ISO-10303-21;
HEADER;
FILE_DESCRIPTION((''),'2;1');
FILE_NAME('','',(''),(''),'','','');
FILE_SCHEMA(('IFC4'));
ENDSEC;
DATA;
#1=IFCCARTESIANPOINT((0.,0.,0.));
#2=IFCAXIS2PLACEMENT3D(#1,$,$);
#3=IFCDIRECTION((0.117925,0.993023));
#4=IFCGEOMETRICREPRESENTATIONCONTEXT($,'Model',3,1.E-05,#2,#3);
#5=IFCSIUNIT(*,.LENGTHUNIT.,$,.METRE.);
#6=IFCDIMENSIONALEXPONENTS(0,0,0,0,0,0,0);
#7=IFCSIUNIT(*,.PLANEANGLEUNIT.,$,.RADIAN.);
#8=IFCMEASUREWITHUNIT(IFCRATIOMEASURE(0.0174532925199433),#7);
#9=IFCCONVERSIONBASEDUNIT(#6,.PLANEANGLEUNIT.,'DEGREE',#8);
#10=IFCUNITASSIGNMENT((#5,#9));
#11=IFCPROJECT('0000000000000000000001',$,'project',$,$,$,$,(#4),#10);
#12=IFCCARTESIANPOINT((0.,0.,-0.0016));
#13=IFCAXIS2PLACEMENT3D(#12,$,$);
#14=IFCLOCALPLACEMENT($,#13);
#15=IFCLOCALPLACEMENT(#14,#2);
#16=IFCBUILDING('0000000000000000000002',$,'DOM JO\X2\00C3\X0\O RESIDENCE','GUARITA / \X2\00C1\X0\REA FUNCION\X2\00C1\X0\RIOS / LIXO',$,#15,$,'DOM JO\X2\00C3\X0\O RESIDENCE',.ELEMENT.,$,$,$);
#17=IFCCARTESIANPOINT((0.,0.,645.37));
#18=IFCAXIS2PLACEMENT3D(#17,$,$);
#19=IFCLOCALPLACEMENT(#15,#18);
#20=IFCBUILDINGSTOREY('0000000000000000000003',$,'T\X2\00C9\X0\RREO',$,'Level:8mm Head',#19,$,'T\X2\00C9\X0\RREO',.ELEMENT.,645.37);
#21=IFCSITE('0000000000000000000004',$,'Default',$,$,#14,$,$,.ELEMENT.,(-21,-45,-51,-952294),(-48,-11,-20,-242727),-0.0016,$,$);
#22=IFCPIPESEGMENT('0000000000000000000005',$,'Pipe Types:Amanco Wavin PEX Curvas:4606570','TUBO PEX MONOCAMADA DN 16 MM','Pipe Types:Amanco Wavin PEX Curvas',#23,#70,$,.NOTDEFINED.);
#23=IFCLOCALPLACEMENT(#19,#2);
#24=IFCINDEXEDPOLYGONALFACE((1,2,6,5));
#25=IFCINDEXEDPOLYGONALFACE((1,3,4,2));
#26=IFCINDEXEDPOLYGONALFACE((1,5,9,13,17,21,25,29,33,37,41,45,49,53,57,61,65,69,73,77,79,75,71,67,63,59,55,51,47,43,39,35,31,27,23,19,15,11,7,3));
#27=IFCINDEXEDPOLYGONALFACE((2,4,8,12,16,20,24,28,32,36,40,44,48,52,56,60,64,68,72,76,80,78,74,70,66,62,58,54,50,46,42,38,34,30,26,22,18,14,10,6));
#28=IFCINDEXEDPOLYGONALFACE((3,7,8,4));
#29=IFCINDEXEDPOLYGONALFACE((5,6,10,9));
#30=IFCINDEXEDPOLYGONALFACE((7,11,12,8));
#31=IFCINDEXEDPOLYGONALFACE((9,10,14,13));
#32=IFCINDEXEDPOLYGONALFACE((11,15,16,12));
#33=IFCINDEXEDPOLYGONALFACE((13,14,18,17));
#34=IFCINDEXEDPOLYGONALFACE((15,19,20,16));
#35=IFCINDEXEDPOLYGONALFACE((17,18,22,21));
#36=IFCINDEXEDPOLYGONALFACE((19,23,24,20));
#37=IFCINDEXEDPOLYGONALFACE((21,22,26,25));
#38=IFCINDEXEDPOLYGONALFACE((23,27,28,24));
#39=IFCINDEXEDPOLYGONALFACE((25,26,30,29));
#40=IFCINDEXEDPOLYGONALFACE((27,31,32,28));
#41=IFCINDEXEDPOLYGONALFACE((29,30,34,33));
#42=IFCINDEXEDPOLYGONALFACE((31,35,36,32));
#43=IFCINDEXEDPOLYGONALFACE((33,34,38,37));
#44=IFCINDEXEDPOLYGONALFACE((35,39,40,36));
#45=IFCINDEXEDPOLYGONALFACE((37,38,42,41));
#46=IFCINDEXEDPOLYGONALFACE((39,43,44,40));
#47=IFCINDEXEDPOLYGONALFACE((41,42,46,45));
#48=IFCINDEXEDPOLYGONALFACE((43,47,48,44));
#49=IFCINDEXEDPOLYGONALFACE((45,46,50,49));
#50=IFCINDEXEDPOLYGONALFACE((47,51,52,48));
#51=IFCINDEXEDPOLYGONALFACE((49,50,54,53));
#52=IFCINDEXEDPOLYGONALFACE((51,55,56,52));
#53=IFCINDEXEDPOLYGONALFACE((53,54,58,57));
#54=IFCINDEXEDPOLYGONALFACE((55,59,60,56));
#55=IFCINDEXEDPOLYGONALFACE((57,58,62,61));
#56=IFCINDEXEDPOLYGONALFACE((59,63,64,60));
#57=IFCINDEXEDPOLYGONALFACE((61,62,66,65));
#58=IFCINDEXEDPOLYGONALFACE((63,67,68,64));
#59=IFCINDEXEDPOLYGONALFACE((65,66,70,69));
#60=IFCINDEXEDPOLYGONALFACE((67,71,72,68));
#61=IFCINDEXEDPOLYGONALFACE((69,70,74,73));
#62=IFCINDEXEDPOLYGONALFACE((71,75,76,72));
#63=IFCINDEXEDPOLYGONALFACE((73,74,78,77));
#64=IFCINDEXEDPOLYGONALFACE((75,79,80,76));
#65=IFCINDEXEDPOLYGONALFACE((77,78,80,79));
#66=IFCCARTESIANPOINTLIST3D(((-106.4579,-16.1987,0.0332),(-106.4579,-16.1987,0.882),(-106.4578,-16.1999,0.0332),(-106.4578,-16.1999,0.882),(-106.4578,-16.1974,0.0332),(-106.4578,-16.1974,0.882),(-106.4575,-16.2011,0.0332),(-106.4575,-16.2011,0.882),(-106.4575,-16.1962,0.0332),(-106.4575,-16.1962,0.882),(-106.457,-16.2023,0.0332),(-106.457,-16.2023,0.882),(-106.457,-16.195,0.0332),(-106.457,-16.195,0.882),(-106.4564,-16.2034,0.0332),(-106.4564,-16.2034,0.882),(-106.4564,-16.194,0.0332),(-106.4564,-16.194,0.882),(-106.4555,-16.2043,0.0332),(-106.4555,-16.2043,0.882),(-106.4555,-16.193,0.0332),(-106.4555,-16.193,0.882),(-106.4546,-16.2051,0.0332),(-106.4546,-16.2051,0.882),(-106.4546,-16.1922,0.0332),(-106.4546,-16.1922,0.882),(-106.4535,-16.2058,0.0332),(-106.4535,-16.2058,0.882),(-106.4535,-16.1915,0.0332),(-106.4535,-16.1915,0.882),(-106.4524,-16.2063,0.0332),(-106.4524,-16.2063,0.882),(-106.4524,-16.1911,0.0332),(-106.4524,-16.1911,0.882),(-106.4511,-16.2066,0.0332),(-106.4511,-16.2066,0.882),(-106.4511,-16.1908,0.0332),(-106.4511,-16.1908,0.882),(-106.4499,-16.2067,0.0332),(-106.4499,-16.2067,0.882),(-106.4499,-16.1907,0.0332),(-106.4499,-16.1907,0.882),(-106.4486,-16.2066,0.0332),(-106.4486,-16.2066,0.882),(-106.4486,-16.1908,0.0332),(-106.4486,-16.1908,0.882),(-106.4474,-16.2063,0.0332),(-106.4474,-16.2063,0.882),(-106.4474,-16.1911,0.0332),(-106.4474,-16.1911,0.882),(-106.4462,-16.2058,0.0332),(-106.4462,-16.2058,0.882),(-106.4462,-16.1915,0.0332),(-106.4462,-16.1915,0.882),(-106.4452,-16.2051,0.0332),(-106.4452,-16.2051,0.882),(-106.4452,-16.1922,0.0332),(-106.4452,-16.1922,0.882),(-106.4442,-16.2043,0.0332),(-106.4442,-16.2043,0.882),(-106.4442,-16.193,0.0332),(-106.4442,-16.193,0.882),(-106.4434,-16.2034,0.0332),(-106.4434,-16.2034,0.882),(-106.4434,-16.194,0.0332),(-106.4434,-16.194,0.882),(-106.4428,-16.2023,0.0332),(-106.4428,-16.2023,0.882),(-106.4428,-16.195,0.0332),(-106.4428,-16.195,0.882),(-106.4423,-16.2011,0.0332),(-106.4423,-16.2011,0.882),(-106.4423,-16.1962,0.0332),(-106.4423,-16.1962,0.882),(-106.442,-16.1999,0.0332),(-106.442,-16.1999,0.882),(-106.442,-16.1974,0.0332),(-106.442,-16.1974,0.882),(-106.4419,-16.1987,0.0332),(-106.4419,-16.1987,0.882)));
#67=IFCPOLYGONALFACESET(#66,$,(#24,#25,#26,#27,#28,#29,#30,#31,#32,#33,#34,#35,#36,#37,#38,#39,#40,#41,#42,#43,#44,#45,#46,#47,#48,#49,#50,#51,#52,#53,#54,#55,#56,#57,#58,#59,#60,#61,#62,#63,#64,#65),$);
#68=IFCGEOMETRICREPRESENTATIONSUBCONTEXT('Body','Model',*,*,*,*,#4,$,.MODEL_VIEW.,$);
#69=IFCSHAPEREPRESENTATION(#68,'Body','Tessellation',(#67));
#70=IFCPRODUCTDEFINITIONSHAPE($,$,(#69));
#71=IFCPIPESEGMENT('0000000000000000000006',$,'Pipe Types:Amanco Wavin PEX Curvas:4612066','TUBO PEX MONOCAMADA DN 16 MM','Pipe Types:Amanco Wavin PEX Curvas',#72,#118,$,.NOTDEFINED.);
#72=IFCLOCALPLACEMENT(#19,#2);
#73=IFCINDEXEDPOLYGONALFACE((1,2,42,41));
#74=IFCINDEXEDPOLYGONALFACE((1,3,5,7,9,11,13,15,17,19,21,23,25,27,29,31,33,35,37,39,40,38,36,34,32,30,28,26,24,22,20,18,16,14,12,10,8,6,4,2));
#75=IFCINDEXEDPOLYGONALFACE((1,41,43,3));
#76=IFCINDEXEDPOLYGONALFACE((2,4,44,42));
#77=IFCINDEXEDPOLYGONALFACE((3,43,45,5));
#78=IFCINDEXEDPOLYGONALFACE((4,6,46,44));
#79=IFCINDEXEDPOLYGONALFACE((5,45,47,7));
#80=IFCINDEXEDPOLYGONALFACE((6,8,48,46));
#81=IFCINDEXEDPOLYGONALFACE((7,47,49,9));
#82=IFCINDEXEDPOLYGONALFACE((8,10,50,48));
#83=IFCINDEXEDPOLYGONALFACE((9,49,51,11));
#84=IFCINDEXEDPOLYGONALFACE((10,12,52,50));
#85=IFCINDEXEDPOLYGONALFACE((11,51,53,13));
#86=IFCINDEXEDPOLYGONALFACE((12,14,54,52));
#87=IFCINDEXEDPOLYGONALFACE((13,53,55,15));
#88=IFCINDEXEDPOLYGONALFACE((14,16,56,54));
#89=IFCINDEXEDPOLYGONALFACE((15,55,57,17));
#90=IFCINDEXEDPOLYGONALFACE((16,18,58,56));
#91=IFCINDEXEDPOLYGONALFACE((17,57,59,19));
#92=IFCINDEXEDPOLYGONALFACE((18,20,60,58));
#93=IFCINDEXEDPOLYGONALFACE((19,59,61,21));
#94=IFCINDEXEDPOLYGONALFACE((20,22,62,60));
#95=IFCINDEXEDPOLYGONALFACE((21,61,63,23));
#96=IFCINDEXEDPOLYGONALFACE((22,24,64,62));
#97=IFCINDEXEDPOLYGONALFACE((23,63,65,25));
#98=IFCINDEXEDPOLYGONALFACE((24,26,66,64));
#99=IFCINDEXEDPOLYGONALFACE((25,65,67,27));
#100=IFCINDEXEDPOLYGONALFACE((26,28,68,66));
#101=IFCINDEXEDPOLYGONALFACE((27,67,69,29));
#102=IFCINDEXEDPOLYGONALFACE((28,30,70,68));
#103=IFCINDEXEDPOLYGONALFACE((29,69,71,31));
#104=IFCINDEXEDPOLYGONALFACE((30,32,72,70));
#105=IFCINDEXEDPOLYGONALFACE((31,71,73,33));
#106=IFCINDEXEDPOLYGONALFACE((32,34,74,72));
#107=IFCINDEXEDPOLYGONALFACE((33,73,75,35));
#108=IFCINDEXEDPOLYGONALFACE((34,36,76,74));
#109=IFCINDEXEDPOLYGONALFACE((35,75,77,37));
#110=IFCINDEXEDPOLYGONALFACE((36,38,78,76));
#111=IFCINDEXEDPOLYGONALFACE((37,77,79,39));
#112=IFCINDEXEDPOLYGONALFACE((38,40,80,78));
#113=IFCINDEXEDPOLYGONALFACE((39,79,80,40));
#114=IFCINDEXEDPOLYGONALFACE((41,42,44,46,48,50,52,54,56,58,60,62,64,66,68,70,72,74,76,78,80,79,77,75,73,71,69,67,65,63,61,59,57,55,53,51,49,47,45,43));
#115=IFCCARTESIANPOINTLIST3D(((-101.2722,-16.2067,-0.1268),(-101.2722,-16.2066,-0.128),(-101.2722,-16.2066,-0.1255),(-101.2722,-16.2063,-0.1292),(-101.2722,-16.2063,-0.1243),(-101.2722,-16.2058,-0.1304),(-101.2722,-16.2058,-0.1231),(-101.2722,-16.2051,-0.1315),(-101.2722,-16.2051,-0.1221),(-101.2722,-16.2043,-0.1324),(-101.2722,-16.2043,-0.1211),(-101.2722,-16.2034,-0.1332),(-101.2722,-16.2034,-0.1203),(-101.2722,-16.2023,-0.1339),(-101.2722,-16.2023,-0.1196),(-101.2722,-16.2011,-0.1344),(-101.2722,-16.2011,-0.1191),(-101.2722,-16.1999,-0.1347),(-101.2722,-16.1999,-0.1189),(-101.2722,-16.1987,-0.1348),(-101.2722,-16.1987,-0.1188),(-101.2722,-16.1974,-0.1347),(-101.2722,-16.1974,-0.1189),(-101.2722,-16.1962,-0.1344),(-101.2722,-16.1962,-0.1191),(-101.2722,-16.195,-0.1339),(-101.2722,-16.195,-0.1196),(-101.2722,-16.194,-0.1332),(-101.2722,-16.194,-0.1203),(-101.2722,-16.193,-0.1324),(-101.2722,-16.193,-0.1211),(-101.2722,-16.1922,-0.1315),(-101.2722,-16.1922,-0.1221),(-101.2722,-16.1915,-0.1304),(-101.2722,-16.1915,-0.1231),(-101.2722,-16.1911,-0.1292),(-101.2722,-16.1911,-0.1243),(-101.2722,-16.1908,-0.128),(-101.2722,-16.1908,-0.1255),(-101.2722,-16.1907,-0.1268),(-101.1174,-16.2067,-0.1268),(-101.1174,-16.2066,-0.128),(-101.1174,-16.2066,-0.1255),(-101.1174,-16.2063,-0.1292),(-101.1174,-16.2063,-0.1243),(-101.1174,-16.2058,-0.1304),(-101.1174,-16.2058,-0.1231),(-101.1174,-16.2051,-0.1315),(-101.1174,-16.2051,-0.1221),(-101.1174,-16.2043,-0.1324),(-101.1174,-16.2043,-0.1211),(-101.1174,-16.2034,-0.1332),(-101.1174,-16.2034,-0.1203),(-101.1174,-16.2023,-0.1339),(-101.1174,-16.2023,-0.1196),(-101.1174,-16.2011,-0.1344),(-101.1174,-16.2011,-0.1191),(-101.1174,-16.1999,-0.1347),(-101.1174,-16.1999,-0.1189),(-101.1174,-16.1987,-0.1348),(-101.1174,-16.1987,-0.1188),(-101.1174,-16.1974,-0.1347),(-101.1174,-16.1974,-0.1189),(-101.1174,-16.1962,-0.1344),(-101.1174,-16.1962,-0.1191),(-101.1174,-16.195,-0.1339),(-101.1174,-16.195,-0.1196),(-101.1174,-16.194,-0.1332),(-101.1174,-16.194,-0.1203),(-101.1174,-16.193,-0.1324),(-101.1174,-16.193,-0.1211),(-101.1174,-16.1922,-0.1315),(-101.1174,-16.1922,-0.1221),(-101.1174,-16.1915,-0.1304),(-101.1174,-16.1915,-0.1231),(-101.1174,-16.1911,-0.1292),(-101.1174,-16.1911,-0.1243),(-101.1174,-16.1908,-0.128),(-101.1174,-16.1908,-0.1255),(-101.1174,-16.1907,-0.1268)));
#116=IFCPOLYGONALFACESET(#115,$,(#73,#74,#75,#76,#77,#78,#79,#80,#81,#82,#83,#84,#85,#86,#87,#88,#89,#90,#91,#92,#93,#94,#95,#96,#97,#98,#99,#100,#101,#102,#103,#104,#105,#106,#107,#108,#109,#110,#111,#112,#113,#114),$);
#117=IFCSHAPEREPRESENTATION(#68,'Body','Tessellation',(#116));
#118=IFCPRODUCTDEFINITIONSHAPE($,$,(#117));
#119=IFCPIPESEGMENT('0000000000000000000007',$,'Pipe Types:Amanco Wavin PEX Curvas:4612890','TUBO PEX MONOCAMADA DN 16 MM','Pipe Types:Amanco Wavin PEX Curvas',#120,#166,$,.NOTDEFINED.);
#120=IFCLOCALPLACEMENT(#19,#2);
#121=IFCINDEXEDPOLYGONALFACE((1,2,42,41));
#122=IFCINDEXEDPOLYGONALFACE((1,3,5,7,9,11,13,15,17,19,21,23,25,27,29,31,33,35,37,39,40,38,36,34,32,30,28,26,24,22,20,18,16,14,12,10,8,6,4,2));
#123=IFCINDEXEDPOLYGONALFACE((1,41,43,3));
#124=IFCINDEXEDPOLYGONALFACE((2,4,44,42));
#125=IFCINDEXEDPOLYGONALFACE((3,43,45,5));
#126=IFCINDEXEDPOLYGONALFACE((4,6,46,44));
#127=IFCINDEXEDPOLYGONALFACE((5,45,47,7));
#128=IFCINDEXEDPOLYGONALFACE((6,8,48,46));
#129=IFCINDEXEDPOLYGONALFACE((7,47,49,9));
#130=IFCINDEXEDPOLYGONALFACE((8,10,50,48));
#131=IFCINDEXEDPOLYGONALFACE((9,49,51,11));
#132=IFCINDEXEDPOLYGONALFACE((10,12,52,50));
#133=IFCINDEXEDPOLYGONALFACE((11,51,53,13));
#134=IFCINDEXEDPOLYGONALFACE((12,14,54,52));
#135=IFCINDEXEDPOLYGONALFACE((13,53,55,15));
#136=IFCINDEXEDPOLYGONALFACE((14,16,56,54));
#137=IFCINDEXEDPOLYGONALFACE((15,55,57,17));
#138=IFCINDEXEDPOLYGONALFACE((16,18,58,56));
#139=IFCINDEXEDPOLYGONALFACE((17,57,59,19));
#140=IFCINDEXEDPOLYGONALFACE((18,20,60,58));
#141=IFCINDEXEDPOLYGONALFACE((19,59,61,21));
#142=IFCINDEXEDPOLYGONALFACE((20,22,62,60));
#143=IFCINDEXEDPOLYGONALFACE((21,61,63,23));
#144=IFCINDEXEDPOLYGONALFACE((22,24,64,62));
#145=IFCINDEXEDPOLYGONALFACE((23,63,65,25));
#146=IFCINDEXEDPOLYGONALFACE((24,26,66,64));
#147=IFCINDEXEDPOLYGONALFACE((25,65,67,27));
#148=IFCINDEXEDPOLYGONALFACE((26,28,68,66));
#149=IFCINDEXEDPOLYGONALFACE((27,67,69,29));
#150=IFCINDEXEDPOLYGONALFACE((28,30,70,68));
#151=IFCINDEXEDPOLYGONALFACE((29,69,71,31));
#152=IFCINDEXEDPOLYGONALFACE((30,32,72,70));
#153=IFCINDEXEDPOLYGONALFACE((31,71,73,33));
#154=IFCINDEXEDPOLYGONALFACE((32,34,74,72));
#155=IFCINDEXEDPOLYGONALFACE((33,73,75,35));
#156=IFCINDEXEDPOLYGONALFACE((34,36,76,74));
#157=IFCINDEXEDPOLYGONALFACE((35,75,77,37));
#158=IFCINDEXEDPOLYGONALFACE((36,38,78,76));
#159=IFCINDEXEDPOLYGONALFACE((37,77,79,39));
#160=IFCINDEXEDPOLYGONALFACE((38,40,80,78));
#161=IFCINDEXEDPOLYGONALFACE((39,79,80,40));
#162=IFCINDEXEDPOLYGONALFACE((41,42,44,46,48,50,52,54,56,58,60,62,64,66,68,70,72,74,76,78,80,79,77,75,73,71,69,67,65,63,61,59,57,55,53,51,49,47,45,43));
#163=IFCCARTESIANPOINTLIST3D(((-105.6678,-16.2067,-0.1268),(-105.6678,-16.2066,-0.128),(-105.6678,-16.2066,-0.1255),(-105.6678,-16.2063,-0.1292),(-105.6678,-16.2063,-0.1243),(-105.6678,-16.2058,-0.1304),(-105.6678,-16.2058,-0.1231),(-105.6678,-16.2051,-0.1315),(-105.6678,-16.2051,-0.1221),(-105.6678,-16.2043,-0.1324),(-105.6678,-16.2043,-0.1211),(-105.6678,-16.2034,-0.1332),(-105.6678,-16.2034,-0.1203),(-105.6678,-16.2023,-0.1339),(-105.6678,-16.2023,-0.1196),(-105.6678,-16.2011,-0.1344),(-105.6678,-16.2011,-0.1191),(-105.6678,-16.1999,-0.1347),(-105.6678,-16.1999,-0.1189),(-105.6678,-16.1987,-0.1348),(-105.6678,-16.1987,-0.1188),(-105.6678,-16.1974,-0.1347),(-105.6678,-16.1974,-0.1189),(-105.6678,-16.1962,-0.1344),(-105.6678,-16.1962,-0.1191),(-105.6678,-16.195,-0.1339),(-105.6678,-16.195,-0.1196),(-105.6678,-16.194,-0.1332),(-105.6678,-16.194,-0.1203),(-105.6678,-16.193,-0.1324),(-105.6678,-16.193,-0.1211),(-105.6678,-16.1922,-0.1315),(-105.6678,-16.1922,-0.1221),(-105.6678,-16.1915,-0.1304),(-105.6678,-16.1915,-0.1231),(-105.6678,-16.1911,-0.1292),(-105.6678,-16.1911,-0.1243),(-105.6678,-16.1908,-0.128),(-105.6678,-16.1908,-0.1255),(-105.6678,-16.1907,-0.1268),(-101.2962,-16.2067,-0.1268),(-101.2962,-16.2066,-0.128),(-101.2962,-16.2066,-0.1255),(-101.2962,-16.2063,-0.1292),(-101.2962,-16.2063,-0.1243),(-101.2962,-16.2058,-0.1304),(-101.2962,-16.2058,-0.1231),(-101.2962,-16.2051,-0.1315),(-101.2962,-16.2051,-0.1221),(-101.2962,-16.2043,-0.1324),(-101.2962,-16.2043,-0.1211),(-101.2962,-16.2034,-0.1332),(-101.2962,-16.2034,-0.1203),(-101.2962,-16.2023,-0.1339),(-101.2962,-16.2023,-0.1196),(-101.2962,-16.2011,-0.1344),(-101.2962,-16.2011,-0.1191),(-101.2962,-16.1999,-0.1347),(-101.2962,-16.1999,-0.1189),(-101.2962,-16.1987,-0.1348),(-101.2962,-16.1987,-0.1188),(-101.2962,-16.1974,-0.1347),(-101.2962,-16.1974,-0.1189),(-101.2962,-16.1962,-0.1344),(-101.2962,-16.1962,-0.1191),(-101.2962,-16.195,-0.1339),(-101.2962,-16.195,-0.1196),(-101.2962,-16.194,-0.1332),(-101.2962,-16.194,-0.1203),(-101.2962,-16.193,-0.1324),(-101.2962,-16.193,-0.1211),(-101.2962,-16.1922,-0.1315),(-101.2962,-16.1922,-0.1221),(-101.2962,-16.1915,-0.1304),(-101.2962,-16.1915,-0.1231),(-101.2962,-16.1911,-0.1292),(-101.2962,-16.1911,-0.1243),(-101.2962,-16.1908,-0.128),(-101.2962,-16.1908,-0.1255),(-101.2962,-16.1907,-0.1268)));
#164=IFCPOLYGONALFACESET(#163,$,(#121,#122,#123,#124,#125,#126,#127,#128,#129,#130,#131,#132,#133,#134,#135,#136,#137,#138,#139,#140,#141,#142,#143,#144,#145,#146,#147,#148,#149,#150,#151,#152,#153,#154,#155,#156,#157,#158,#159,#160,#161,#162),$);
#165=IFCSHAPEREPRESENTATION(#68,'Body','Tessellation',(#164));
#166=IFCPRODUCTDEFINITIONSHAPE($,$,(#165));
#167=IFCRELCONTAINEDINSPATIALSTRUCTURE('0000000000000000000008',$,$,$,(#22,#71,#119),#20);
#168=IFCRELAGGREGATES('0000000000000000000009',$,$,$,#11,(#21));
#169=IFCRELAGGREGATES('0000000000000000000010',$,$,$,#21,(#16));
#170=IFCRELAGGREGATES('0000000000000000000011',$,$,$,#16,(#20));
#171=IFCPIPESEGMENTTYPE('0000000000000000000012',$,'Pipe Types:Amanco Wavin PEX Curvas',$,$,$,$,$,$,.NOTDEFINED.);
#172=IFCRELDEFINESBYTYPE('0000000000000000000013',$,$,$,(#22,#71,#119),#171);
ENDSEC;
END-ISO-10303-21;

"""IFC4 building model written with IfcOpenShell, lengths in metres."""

from ifc_helpers import new_model, entity, si_unit, converted_unit, direction, frame, origin, place, context, subcontext, project, spatial, indexed_curve, outline, extrude, type_object, element, save


model = new_model("IFC4")

# Units and contexts
model_context = context("Model", 3, precision=1e-05, world=origin(), true_north=direction((0.117925, 0.993023)))
body_context = subcontext(model_context, "Body", "Model", "MODEL_VIEW")
ifc_project = project(units=[si_unit("LENGTHUNIT", "METRE"), converted_unit("PLANEANGLEUNIT", "DEGREE", entity("IfcRatioMeasure", 0.0174532925199433), si_unit("PLANEANGLEUNIT", "RADIAN"), dimensions=[0, 0, 0, 0, 0, 0, 0])], contexts=[model_context])

# Site, building, storey
site_placement = place(None, frame((0.0, 0.0, -0.0016)))
site = spatial("IfcSite", under=ifc_project, at=site_placement, Name="Default", CompositionType="ELEMENT", RefLatitude=(-21, -45, -51, -952294), RefLongitude=(-48, -11, -20, -242727), RefElevation=-0.0016)
building_placement = place(site_placement, origin())
building = spatial("IfcBuilding", under=site, at=building_placement, Name="DOM JOÃO RESIDENCE", Description="GUARITA / ÁREA FUNCIONÁRIOS / LIXO", LongName="DOM JOÃO RESIDENCE", CompositionType="ELEMENT")
storey_placement = place(building_placement, frame((0.0, 0.0, 645.37)))
storey = spatial("IfcBuildingStorey", under=building, at=storey_placement, Name="TÉRREO", ObjectType="Level:8mm Head", LongName="TÉRREO", CompositionType="ELEMENT", Elevation=645.37)

# Pipe segments
pipe_segment_type_1 = type_object("IfcPipeSegmentType", Name="Pipe Types:Amanco Wavin PEX Curvas", PredefinedType="NOTDEFINED")
pipe_segment_1_placement = place(storey_placement, frame((-106.4595, -16.2083, 0.0332)))
element("IfcPipeSegment", 1, at=pipe_segment_1_placement, inside=storey, type_object=pipe_segment_type_1, Name="Pipe Types:Amanco Wavin PEX Curvas:4606570", Description="TUBO PEX MONOCAMADA DN 16 MM", ObjectType="Pipe Types:Amanco Wavin PEX Curvas", PredefinedType="NOTDEFINED", context=body_context, shape_type="SweptSolid", body=[
    extrude(outline(indexed_curve([(0.008, 0.0), (0.0079, 0.0013), (0.0076, 0.0025), (0.0071, 0.0036), (0.0065, 0.0047), (0.0057, 0.0057), (0.0047, 0.0065), (0.0036, 0.0071), (0.0025, 0.0076), (0.0013, 0.0079), (0.0, 0.008), (-0.0013, 0.0079), (-0.0025, 0.0076), (-0.0036, 0.0071), (-0.0047, 0.0065), (-0.0057, 0.0057), (-0.0065, 0.0047), (-0.0071, 0.0036), (-0.0076, 0.0025), (-0.0079, 0.0013), (-0.008, 0.0), (-0.0079, -0.0013), (-0.0076, -0.0025), (-0.0071, -0.0036), (-0.0065, -0.0047), (-0.0057, -0.0057), (-0.0047, -0.0065), (-0.0036, -0.0071), (-0.0025, -0.0076), (-0.0013, -0.0079), (0.0, -0.008), (0.0013, -0.0079), (0.0025, -0.0076), (0.0036, -0.0071), (0.0047, -0.0065), (0.0057, -0.0057), (0.0065, -0.0047), (0.0071, -0.0036), (0.0076, -0.0025), (0.0079, -0.0013), (0.008, 0.0)], self_intersect=False)), frame((0.0096, 0.0096, 0.0)), (0.0, 0.0, 1.0), 0.8488),
])
pipe_segment_2_placement = place(storey_placement, frame((-101.2722, -16.2083, -0.1364)))
element("IfcPipeSegment", 2, at=pipe_segment_2_placement, inside=storey, type_object=pipe_segment_type_1, Name="Pipe Types:Amanco Wavin PEX Curvas:4612066", Description="TUBO PEX MONOCAMADA DN 16 MM", ObjectType="Pipe Types:Amanco Wavin PEX Curvas", PredefinedType="NOTDEFINED", context=body_context, shape_type="SweptSolid", body=[
    extrude(outline(indexed_curve([(0.008, 0.0), (0.0079, 0.0013), (0.0076, 0.0025), (0.0071, 0.0036), (0.0065, 0.0047), (0.0057, 0.0057), (0.0047, 0.0065), (0.0036, 0.0071), (0.0025, 0.0076), (0.0013, 0.0079), (0.0, 0.008), (-0.0013, 0.0079), (-0.0025, 0.0076), (-0.0036, 0.0071), (-0.0047, 0.0065), (-0.0057, 0.0057), (-0.0065, 0.0047), (-0.0071, 0.0036), (-0.0076, 0.0025), (-0.0079, 0.0013), (-0.008, 0.0), (-0.0079, -0.0013), (-0.0076, -0.0025), (-0.0071, -0.0036), (-0.0065, -0.0047), (-0.0057, -0.0057), (-0.0047, -0.0065), (-0.0036, -0.0071), (-0.0025, -0.0076), (-0.0013, -0.0079), (0.0, -0.008), (0.0013, -0.0079), (0.0025, -0.0076), (0.0036, -0.0071), (0.0047, -0.0065), (0.0057, -0.0057), (0.0065, -0.0047), (0.0071, -0.0036), (0.0076, -0.0025), (0.0079, -0.0013), (0.008, 0.0)], self_intersect=False)), frame((0.0, 0.0096, 0.0096), z_axis=(1.0, 0.0, 0.0), x_axis=(0.0, -1.0, 0.0)), (0.0, 0.0, 1.0), 0.1549),
])
pipe_segment_3_placement = place(storey_placement, frame((-105.6678, -16.2083, -0.1364)))
element("IfcPipeSegment", 3, at=pipe_segment_3_placement, inside=storey, type_object=pipe_segment_type_1, Name="Pipe Types:Amanco Wavin PEX Curvas:4612890", Description="TUBO PEX MONOCAMADA DN 16 MM", ObjectType="Pipe Types:Amanco Wavin PEX Curvas", PredefinedType="NOTDEFINED", context=body_context, shape_type="SweptSolid", body=[
    extrude(outline(indexed_curve([(0.008, 0.0), (0.0079, 0.0013), (0.0076, 0.0025), (0.0071, 0.0036), (0.0065, 0.0047), (0.0057, 0.0057), (0.0047, 0.0065), (0.0036, 0.0071), (0.0025, 0.0076), (0.0013, 0.0079), (0.0, 0.008), (-0.0013, 0.0079), (-0.0025, 0.0076), (-0.0036, 0.0071), (-0.0047, 0.0065), (-0.0057, 0.0057), (-0.0065, 0.0047), (-0.0071, 0.0036), (-0.0076, 0.0025), (-0.0079, 0.0013), (-0.008, 0.0), (-0.0079, -0.0013), (-0.0076, -0.0025), (-0.0071, -0.0036), (-0.0065, -0.0047), (-0.0057, -0.0057), (-0.0047, -0.0065), (-0.0036, -0.0071), (-0.0025, -0.0076), (-0.0013, -0.0079), (0.0, -0.008), (0.0013, -0.0079), (0.0025, -0.0076), (0.0036, -0.0071), (0.0047, -0.0065), (0.0057, -0.0057), (0.0065, -0.0047), (0.0071, -0.0036), (0.0076, -0.0025), (0.0079, -0.0013), (0.008, 0.0)], self_intersect=False)), frame((0.0, 0.0096, 0.0096), z_axis=(1.0, 0.0, 0.0), x_axis=(0.0, -1.0, 0.0)), (0.0, 0.0, 1.0), 4.3716),
])

save(model, "model.ifc")
